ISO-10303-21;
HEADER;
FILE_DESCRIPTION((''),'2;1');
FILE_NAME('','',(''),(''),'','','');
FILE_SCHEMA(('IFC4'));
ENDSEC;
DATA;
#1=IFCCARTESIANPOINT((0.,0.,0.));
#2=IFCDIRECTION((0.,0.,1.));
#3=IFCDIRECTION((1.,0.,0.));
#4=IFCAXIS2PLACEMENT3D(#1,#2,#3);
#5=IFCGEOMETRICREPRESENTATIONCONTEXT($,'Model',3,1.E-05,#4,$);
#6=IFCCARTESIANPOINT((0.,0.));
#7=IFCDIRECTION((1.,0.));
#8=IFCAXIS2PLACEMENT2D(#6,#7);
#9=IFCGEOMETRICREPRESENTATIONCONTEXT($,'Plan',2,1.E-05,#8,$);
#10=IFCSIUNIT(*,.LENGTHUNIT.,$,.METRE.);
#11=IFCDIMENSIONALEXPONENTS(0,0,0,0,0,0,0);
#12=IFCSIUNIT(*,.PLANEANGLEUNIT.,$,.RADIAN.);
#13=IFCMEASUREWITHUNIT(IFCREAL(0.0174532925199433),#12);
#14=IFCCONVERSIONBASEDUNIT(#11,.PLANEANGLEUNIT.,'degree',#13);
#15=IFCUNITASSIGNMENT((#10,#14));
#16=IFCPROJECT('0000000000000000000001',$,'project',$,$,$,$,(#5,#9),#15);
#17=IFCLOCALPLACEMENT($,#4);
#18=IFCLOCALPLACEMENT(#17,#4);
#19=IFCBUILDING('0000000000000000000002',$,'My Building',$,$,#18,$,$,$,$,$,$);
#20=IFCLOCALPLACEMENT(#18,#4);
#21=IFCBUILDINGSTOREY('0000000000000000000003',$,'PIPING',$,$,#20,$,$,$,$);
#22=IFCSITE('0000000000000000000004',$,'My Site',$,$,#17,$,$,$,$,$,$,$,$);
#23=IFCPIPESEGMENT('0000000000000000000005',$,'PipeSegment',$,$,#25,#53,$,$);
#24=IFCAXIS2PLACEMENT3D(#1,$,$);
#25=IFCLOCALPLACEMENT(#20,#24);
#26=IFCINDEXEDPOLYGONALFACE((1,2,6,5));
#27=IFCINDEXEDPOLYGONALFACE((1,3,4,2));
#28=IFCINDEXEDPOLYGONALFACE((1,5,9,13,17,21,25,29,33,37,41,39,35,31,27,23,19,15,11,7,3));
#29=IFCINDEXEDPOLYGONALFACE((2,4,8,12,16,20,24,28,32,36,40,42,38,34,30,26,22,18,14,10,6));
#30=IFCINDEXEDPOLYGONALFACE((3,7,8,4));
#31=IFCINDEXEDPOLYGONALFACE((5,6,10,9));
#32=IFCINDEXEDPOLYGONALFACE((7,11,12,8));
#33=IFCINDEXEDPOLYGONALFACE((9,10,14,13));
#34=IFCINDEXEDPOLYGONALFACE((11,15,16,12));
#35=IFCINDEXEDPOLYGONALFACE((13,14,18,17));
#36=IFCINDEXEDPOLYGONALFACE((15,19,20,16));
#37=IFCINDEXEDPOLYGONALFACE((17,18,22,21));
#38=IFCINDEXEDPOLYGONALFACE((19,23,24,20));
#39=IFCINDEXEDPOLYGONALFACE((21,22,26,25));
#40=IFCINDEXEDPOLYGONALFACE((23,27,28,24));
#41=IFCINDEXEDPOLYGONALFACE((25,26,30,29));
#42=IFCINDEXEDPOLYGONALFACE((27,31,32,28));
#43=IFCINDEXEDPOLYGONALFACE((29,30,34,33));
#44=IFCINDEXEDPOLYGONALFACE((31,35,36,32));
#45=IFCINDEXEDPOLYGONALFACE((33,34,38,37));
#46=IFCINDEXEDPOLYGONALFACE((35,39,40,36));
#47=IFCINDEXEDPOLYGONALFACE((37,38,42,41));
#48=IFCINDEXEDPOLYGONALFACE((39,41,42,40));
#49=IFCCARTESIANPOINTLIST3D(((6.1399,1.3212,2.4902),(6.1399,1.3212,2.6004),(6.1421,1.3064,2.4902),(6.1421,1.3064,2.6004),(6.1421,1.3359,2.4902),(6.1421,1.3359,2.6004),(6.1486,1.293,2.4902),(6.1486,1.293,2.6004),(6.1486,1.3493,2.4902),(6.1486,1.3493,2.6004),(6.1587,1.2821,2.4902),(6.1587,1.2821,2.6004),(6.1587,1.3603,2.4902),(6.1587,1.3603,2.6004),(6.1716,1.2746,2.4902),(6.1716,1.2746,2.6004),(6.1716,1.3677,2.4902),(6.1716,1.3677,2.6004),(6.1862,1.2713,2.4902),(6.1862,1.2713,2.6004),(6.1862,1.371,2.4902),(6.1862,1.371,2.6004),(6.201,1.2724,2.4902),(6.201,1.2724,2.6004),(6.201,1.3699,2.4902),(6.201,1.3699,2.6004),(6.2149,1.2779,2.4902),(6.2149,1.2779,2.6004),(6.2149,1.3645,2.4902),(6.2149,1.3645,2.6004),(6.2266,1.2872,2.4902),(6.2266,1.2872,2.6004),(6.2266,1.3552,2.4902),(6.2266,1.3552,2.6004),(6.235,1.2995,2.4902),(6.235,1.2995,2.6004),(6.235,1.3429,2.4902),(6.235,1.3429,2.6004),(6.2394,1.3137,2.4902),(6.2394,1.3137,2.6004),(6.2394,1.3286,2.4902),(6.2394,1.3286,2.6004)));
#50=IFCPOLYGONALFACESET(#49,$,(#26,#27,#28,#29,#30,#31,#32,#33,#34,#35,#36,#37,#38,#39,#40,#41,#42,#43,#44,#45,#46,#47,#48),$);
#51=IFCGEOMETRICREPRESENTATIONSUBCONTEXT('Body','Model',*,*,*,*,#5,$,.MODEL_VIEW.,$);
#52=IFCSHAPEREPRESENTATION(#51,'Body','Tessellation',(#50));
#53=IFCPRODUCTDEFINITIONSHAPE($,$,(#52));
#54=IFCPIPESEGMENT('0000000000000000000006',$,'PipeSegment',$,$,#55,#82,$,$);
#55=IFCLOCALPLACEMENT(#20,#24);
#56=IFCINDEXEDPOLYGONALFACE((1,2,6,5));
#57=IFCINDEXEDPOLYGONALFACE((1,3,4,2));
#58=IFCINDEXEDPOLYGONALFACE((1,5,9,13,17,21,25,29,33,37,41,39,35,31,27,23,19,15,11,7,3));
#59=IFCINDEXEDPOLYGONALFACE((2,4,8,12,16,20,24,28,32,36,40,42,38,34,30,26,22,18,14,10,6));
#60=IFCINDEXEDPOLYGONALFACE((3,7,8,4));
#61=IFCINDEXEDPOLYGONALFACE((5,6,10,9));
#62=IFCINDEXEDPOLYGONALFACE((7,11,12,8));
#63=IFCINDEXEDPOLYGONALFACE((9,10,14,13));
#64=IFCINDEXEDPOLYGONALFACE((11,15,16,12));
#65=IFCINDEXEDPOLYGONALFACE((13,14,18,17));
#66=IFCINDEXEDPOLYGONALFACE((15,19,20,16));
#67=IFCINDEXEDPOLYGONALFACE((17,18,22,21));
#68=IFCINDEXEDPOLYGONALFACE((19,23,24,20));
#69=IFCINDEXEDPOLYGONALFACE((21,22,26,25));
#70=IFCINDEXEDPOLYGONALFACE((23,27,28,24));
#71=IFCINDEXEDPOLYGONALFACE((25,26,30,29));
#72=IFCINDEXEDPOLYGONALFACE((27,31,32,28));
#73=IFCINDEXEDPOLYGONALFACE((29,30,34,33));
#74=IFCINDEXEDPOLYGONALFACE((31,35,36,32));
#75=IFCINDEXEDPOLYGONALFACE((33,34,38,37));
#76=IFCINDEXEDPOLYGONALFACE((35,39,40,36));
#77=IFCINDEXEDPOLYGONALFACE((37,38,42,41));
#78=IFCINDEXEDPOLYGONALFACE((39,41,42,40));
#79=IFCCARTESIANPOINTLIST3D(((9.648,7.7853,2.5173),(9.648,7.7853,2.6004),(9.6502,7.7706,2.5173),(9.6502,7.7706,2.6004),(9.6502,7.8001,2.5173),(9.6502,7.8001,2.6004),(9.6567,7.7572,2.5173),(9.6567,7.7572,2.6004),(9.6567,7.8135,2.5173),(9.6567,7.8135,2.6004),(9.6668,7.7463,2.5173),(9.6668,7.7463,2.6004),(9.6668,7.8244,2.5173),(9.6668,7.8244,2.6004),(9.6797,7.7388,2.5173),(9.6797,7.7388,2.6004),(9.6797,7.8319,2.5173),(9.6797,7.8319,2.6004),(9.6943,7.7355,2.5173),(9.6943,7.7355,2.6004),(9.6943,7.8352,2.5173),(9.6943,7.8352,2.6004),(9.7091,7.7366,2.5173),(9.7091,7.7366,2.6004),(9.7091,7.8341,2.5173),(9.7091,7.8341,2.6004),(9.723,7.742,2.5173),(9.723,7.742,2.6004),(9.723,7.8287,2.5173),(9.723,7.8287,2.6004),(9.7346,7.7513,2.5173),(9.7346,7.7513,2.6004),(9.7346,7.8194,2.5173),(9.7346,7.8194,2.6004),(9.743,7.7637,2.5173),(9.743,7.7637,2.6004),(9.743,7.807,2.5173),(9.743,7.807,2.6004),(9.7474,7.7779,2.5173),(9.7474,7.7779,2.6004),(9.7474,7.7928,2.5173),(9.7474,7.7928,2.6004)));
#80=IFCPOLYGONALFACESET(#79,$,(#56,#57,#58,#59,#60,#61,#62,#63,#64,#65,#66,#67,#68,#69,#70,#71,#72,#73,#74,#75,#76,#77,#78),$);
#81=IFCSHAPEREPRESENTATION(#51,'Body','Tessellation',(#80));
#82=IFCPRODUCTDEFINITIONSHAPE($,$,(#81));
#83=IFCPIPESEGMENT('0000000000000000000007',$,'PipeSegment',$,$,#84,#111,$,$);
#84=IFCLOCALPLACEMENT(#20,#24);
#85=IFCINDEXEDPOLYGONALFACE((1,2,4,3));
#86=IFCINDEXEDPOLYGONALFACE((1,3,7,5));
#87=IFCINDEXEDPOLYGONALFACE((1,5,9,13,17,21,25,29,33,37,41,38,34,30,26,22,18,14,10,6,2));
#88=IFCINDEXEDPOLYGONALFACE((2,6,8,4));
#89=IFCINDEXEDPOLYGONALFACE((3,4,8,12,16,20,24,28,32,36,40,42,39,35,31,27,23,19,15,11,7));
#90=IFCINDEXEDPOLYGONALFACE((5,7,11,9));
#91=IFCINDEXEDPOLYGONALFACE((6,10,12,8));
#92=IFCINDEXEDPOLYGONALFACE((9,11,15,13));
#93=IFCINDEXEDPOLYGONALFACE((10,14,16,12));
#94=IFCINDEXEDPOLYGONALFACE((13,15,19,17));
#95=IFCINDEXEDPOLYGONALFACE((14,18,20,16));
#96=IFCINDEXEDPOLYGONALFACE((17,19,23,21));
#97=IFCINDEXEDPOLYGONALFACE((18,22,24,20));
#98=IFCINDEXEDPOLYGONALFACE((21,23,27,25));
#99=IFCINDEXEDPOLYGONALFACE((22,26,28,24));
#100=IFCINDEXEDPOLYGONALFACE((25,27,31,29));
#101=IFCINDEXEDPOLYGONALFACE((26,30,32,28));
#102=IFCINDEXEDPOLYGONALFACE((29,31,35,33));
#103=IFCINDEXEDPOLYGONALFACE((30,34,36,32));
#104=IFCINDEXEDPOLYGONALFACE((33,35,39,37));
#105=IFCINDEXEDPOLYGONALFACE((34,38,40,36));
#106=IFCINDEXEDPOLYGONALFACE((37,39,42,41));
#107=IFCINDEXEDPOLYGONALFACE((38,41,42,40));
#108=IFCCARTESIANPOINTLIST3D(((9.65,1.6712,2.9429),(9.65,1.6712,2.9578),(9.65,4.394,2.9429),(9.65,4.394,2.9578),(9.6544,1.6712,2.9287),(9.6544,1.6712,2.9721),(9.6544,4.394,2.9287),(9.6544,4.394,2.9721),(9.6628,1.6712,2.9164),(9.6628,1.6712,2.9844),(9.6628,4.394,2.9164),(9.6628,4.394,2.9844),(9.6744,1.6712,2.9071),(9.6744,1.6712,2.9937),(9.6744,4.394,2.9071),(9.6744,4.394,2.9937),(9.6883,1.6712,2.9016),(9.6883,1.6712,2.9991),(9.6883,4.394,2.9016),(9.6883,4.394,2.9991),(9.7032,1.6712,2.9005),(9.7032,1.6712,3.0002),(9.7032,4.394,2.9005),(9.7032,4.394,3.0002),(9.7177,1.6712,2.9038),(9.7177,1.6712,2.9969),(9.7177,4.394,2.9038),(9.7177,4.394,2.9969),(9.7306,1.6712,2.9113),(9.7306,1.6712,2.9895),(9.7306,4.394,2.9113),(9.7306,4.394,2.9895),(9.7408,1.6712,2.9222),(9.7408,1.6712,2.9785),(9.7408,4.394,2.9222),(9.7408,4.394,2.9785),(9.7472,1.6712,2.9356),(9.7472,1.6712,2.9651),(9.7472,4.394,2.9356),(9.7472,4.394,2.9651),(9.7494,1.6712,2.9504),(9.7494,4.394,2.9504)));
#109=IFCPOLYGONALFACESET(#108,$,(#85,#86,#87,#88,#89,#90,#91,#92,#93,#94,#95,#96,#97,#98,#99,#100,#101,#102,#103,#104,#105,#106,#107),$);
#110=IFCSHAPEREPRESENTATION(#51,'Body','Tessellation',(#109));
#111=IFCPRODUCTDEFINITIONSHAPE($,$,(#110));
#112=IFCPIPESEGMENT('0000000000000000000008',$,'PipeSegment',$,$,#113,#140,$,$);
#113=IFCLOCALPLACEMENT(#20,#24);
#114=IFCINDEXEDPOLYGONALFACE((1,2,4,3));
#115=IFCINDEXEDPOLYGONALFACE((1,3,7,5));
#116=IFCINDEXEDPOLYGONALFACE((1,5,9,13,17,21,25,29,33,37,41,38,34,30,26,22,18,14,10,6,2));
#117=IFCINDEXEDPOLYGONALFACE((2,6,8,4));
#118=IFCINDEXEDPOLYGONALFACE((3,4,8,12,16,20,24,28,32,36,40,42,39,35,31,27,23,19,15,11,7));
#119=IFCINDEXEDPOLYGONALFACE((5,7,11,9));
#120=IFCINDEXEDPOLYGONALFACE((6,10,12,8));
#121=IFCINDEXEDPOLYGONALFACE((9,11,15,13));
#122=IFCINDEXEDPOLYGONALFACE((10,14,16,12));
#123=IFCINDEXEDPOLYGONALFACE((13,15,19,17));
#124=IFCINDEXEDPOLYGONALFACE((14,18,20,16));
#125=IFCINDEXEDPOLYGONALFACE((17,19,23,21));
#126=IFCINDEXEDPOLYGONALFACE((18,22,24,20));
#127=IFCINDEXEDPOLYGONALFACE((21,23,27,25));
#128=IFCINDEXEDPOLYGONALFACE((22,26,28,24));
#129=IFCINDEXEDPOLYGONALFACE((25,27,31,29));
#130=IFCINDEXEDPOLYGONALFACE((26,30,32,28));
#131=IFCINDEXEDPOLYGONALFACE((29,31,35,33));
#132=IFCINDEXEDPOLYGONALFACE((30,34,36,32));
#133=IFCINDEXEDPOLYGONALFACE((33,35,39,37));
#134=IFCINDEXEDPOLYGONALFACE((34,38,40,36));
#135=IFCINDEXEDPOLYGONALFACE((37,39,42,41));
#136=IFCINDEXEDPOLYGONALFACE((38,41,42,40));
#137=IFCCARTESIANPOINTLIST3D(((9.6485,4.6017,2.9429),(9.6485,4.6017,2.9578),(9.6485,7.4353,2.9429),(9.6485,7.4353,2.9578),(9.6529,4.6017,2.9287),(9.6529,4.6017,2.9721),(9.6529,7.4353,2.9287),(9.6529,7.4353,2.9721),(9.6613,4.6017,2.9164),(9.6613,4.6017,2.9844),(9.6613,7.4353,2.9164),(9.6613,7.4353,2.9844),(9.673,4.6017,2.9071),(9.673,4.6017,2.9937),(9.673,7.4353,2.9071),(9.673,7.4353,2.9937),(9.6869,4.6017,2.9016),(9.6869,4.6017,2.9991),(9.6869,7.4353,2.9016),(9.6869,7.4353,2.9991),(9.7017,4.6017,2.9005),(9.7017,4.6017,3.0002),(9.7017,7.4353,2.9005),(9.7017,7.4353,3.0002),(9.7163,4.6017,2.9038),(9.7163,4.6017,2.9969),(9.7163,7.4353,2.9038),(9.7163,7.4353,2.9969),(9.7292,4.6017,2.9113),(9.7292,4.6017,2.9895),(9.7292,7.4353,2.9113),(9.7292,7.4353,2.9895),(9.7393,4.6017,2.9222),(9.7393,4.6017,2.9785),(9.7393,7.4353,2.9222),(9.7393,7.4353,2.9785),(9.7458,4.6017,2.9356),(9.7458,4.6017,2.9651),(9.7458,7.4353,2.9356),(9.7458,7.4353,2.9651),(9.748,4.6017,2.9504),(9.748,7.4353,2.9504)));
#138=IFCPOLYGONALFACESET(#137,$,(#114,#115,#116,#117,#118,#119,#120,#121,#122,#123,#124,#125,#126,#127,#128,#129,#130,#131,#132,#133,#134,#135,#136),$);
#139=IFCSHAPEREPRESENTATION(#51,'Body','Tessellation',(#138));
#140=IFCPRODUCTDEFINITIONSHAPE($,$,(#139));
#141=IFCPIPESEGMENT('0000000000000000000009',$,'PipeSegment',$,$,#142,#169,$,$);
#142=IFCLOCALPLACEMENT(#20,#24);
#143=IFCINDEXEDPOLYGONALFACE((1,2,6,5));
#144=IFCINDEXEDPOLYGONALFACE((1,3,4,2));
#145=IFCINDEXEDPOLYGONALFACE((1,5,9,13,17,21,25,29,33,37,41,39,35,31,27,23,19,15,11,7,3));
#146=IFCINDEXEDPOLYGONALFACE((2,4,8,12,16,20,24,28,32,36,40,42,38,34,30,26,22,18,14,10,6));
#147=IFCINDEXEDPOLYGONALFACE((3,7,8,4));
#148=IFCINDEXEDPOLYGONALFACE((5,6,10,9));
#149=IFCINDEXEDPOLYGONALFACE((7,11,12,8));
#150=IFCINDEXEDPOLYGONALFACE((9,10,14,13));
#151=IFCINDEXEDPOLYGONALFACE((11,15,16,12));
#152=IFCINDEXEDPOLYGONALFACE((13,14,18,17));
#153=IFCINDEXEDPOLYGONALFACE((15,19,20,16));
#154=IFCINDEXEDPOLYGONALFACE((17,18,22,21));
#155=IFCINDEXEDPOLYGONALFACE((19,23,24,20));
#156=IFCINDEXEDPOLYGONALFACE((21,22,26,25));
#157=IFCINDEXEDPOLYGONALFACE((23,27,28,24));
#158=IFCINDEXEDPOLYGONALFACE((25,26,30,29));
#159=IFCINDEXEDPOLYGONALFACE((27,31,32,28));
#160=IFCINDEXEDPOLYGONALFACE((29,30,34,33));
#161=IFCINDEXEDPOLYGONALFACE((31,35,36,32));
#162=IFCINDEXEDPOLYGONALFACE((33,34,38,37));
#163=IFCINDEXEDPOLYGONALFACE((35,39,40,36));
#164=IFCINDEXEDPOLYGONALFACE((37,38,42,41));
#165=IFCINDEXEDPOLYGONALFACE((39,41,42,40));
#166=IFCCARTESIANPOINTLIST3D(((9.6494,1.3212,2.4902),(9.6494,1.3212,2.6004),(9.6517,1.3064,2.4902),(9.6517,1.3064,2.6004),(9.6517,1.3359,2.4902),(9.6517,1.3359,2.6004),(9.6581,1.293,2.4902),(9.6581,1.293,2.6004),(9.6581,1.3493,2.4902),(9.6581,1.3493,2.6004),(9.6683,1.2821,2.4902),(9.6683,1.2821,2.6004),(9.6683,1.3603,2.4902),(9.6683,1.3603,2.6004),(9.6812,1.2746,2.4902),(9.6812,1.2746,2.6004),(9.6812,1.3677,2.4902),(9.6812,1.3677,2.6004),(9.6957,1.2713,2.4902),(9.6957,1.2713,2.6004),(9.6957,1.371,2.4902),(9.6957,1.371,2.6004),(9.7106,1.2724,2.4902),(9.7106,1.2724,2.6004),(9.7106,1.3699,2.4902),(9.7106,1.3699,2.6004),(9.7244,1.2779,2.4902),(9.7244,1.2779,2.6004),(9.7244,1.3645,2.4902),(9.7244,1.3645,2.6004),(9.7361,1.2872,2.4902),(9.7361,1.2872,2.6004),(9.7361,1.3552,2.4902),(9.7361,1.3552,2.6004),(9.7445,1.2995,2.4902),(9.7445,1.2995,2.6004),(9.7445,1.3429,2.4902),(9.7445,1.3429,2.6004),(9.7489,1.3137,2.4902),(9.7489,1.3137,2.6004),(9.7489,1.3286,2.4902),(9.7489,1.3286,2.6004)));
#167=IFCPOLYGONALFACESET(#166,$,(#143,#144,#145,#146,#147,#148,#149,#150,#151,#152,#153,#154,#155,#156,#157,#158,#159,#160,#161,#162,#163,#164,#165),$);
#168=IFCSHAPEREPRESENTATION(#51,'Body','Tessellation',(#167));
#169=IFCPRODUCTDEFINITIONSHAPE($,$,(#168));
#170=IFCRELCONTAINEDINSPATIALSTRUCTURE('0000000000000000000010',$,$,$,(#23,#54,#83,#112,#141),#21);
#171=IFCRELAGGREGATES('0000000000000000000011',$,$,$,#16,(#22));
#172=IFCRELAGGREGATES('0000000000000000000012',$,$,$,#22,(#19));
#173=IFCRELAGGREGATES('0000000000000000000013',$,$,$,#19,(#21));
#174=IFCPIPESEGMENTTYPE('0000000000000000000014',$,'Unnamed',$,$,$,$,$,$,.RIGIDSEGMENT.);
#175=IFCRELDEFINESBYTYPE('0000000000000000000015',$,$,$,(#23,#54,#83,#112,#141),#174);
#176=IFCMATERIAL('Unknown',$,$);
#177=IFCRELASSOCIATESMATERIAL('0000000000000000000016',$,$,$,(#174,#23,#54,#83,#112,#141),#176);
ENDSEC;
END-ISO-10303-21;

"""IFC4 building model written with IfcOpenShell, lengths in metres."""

from ifc_helpers import new_model, entity, si_unit, converted_unit, frame, origin_with_axes, origin_2d_with_axis, place, context, subcontext, project, spatial, circle, extrude, material, material_profile, profile_set, profile_usage, type_object, element, save


model = new_model("IFC4")

# Units and contexts
model_context = context("Model", 3, precision=1e-05, world=origin_with_axes())
plan_context = context("Plan", 2, precision=1e-05, world=origin_2d_with_axis())
body_context = subcontext(model_context, "Body", "Model", "MODEL_VIEW")
ifc_project = project(units=[si_unit("LENGTHUNIT", "METRE"), converted_unit("PLANEANGLEUNIT", "degree", entity("IfcReal", 0.0174532925199433), si_unit("PLANEANGLEUNIT", "RADIAN"), dimensions=[0, 0, 0, 0, 0, 0, 0])], contexts=[model_context, plan_context])

# Site, building, storey
site_placement = place(None, origin_with_axes())
site = spatial("IfcSite", under=ifc_project, at=site_placement, Name="My Site")
building_placement = place(site_placement, origin_with_axes())
building = spatial("IfcBuilding", under=site, at=building_placement, Name="My Building")
storey_placement = place(building_placement, origin_with_axes())
storey = spatial("IfcBuildingStorey", under=building, at=storey_placement, Name="PIPING")

# Pipe segments
ifc_material = material(Name="Unknown")
ifc_material_profile_1 = material_profile(ifc_material, circle(Radius=0.05))
ifc_profile_set_1 = profile_set([ifc_material_profile_1])
pipe_segment_type = type_object("IfcPipeSegmentType", Name="Unnamed", PredefinedType="RIGIDSEGMENT", material=ifc_profile_set_1)
ifc_profile_usage_1 = profile_usage(ifc_profile_set_1, cardinal=5)
pipe_segment_1_placement = place(storey_placement, frame((6.1899, 1.3212, 2.6004), z_axis=(0.0, 0.0, -1.0), x_axis=(-1.0, 0.0, 0.0)))
element("IfcPipeSegment", 1, at=pipe_segment_1_placement, inside=storey, type_object=pipe_segment_type, material=ifc_profile_usage_1, Name="PipeSegment", context=body_context, shape_type="SweptSolid", body=[
    extrude(circle(Radius=0.05), origin_with_axes(), (0.0, 0.0, 1.0), 0.1102),
])
ifc_profile_usage_2 = profile_usage(ifc_profile_set_1, cardinal=5)
pipe_segment_2_placement = place(storey_placement, frame((9.698, 7.7853, 2.6004), z_axis=(0.0, 0.0, -1.0), x_axis=(-1.0, 0.0, 0.0)))
element("IfcPipeSegment", 2, at=pipe_segment_2_placement, inside=storey, type_object=pipe_segment_type, material=ifc_profile_usage_2, Name="PipeSegment", context=body_context, shape_type="SweptSolid", body=[
    extrude(circle(Radius=0.05), origin_with_axes(), (0.0, 0.0, 1.0), 0.0831),
])
ifc_profile_usage_3 = profile_usage(ifc_profile_set_1, cardinal=5)
pipe_segment_3_placement = place(storey_placement, frame((9.6994, 1.6712, 2.9504), z_axis=(0.0, 1.0, 0.0), x_axis=(1.0, 0.0, 0.0)))
element("IfcPipeSegment", 3, at=pipe_segment_3_placement, inside=storey, type_object=pipe_segment_type, material=ifc_profile_usage_3, Name="PipeSegment", context=body_context, shape_type="SweptSolid", body=[
    extrude(circle(Radius=0.05), origin_with_axes(), (0.0, 0.0, 1.0), 2.7228),
])
ifc_profile_usage_4 = profile_usage(ifc_profile_set_1, cardinal=5)
pipe_segment_4_placement = place(storey_placement, frame((9.698, 4.6017, 2.9504), z_axis=(0.0, 1.0, 0.0), x_axis=(1.0, 0.0, 0.0)))
element("IfcPipeSegment", 4, at=pipe_segment_4_placement, inside=storey, type_object=pipe_segment_type, material=ifc_profile_usage_4, Name="PipeSegment", context=body_context, shape_type="SweptSolid", body=[
    extrude(circle(Radius=0.05), origin_with_axes(), (0.0, 0.0, 1.0), 2.8337),
])
ifc_profile_usage_5 = profile_usage(ifc_profile_set_1, cardinal=5)
pipe_segment_5_placement = place(storey_placement, frame((9.6994, 1.3212, 2.6004), z_axis=(0.0, 0.0, -1.0), x_axis=(-1.0, 0.0, 0.0)))
element("IfcPipeSegment", 5, at=pipe_segment_5_placement, inside=storey, type_object=pipe_segment_type, material=ifc_profile_usage_5, Name="PipeSegment", context=body_context, shape_type="SweptSolid", body=[
    extrude(circle(Radius=0.05), origin_with_axes(), (0.0, 0.0, 1.0), 0.1102),
])

save(model, "model.ifc")
